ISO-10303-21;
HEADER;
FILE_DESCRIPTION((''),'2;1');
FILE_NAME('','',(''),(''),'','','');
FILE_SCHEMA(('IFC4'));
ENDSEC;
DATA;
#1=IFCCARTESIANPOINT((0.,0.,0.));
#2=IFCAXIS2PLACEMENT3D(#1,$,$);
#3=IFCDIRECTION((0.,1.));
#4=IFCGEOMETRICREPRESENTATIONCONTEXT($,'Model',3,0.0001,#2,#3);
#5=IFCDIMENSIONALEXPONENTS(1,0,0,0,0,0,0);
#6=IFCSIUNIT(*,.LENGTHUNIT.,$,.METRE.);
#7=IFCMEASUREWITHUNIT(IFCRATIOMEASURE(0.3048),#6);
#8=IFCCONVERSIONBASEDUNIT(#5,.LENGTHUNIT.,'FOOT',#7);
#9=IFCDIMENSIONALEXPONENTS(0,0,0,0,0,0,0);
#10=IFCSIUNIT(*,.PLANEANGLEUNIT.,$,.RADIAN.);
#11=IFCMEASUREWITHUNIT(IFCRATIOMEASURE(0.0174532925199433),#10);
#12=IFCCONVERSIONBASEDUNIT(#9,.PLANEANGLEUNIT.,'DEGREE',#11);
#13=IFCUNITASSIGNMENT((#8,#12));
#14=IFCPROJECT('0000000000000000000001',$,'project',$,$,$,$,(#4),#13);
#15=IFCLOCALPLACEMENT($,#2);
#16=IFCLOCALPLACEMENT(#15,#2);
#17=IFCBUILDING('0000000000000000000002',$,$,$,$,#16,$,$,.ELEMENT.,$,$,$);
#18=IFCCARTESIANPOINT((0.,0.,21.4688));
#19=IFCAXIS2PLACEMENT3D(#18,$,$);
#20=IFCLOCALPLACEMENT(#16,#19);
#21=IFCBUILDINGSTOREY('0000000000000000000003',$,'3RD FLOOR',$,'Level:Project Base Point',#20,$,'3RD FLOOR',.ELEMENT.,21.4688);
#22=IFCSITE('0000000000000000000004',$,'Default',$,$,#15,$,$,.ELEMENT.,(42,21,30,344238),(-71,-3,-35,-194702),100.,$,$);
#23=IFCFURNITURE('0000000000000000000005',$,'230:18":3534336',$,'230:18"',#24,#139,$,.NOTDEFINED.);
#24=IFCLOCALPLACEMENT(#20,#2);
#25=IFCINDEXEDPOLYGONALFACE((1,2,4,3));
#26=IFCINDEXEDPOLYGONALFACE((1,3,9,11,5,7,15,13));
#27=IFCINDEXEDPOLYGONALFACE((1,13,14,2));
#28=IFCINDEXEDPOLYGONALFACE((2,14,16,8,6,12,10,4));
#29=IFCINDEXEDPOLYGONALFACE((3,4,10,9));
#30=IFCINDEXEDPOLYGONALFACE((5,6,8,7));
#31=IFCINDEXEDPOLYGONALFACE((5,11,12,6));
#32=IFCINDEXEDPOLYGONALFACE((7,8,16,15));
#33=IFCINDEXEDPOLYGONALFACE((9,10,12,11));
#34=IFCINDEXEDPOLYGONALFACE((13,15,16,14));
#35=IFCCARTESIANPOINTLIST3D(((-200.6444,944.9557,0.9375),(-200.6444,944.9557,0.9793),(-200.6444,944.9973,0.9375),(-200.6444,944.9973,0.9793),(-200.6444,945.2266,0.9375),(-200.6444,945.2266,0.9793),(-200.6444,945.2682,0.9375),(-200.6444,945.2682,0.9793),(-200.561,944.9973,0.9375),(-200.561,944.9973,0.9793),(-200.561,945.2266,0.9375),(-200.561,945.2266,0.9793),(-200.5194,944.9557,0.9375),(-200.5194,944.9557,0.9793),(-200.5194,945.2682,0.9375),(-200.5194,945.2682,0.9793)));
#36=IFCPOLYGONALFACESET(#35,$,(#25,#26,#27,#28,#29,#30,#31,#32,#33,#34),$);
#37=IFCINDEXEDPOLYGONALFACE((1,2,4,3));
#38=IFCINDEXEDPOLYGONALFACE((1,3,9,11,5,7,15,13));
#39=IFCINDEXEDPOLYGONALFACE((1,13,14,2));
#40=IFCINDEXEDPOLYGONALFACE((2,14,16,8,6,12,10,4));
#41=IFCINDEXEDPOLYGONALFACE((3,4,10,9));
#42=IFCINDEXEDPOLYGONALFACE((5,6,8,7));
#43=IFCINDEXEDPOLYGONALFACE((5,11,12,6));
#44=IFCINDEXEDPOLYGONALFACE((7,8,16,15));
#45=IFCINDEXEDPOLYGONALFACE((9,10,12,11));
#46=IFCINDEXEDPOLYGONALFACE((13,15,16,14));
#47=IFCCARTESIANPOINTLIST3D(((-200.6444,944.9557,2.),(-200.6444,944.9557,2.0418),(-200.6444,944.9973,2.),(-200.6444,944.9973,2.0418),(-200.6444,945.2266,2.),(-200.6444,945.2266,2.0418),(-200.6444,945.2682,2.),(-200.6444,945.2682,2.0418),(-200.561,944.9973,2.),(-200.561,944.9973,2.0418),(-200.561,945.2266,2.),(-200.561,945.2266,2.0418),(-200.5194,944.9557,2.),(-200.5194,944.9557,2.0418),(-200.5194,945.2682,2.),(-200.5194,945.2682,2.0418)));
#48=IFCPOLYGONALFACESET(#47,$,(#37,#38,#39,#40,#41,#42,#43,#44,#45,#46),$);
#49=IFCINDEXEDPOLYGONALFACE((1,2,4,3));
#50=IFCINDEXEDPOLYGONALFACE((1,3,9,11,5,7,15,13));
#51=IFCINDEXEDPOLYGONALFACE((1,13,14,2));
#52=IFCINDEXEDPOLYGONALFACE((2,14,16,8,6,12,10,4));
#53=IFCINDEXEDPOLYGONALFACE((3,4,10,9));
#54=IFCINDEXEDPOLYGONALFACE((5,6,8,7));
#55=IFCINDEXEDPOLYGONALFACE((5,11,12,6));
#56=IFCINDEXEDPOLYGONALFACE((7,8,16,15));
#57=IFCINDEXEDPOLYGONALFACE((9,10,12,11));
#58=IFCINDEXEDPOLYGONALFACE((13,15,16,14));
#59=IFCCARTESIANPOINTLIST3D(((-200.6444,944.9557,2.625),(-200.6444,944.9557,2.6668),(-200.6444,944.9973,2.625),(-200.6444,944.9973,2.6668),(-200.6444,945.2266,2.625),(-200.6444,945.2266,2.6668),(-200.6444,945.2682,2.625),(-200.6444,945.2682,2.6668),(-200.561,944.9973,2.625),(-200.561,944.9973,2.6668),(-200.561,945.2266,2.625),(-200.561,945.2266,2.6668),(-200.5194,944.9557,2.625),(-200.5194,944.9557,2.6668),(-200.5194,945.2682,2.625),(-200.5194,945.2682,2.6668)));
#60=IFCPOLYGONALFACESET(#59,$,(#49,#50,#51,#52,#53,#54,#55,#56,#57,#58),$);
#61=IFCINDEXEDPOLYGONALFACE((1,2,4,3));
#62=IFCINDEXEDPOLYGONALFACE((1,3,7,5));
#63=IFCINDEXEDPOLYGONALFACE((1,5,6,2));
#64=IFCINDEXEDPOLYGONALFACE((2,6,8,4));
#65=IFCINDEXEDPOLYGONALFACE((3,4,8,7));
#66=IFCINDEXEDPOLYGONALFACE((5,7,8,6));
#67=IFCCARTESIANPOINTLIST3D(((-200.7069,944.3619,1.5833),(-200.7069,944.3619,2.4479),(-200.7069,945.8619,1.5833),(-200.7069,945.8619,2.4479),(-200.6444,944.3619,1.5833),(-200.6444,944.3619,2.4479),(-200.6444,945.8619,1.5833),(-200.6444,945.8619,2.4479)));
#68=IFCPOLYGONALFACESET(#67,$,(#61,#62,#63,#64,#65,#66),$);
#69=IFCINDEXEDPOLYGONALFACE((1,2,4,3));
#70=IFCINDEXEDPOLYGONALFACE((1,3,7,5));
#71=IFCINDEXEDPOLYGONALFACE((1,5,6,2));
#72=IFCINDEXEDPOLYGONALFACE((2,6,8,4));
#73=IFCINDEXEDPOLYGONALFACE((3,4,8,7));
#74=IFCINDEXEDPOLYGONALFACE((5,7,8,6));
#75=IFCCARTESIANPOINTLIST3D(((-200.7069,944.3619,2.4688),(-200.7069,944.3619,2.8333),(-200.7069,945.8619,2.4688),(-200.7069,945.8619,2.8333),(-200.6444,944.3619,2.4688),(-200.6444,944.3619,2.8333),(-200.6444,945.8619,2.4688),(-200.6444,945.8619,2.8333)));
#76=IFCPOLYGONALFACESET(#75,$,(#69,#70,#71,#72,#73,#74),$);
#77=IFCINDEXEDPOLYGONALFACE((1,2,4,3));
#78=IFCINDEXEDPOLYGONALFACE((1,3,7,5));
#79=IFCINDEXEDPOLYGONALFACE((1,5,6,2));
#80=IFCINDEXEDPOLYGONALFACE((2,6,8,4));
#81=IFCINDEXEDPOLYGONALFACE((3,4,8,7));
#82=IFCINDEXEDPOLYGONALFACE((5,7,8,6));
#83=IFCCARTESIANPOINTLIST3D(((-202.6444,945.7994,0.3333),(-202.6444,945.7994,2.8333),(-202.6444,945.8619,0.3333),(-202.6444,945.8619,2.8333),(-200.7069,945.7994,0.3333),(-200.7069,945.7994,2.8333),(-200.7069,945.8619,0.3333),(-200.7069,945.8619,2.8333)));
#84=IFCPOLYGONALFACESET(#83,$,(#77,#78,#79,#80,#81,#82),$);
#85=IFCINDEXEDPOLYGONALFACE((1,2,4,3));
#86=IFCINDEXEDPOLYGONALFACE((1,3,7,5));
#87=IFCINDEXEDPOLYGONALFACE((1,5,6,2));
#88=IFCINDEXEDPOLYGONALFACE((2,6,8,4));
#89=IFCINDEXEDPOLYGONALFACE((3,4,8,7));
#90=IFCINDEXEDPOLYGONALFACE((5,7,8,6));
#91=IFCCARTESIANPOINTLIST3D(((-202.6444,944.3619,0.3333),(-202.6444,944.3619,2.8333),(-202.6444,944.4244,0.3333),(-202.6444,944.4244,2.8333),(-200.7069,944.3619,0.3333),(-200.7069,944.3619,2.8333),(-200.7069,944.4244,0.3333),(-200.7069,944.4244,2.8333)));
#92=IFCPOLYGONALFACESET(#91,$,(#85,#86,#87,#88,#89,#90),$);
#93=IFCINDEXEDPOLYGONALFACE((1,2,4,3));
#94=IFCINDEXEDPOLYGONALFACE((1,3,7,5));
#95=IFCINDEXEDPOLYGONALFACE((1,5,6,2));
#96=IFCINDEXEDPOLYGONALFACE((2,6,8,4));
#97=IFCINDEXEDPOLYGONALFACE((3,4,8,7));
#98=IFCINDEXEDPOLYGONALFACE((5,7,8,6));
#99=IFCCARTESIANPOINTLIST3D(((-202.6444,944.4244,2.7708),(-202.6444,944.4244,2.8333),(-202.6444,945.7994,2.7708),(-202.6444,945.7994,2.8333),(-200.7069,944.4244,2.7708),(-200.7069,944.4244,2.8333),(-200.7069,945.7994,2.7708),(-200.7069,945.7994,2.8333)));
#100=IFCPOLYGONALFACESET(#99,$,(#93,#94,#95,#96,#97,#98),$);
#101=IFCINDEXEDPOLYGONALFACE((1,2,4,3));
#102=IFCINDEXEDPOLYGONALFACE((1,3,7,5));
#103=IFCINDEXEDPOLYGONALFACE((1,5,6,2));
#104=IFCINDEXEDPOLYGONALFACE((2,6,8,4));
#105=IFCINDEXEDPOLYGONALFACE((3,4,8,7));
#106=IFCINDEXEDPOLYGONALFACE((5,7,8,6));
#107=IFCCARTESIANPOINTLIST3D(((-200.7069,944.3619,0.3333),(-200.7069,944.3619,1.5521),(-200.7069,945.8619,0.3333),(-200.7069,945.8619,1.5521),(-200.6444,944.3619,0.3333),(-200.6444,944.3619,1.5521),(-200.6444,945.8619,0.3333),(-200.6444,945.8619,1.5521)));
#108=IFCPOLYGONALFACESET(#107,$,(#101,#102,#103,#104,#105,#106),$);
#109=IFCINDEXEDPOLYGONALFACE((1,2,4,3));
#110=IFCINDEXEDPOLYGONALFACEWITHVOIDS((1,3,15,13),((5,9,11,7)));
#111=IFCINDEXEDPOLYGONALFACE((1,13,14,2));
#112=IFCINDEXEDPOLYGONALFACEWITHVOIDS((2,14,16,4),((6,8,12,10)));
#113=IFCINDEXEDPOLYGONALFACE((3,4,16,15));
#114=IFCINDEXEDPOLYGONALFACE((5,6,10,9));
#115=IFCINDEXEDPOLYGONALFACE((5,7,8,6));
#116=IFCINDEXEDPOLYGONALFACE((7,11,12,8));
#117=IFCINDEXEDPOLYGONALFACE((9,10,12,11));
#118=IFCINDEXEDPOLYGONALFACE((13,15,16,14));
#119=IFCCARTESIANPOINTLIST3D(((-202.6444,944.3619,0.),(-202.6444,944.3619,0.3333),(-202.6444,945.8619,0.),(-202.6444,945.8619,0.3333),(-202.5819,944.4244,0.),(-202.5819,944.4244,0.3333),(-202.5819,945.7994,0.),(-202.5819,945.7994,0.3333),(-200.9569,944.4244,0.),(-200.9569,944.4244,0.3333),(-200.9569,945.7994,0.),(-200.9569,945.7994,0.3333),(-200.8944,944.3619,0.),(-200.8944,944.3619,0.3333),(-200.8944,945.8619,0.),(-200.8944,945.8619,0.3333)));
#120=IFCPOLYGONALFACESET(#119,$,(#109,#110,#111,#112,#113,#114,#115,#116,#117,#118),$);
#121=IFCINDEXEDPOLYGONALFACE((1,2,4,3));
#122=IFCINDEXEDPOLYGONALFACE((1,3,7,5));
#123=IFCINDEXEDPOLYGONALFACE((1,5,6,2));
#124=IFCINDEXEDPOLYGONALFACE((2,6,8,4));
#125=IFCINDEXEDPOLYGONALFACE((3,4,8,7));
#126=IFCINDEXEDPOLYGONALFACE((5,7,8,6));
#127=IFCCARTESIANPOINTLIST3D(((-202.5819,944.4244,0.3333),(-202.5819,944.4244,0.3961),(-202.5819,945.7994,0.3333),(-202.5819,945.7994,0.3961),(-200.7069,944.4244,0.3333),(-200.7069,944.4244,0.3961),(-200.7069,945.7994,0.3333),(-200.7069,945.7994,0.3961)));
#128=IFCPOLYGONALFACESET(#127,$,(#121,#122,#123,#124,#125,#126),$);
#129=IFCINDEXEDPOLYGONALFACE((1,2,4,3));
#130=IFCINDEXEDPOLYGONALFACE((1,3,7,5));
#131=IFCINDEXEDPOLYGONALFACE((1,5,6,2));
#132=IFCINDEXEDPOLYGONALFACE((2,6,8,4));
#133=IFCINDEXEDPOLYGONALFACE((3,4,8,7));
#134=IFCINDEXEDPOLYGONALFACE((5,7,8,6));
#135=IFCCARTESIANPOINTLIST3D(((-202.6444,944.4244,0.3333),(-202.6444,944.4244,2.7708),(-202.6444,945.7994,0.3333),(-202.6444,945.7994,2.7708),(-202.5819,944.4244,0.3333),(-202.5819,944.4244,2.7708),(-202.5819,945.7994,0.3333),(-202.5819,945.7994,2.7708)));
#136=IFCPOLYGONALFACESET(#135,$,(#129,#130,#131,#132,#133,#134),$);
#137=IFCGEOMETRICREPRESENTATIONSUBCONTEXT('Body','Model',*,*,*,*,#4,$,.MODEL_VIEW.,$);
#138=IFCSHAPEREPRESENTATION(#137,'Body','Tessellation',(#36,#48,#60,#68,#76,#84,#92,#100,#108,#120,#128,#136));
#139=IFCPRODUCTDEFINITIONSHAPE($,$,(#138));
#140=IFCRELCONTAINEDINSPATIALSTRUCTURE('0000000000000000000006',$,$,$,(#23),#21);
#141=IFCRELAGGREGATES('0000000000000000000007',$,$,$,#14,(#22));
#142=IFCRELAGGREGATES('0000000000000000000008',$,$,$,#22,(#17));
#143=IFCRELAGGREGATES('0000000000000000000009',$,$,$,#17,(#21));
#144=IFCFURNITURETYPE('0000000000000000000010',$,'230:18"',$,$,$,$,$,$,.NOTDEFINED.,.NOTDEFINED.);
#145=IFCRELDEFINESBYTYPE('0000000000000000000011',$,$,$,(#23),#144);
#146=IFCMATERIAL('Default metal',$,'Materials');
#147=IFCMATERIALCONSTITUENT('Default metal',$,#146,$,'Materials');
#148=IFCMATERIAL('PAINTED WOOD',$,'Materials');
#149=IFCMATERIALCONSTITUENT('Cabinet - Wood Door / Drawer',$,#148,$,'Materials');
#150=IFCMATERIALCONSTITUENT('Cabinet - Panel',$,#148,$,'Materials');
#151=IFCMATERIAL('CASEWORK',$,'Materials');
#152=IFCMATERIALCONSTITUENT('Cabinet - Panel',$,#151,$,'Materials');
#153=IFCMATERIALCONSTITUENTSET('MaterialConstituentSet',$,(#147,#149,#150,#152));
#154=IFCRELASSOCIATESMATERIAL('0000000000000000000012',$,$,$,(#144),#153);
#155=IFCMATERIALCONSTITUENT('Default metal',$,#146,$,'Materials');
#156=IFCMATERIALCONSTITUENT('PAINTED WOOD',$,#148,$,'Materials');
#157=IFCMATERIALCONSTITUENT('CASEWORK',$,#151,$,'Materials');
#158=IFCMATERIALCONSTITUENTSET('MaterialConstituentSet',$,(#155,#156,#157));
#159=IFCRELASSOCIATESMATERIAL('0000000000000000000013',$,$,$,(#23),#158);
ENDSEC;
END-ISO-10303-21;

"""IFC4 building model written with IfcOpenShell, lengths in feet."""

from ifc_helpers import new_model, entity, si_unit, converted_unit, direction, frame, frame_2d, origin, origin_2d_with_axis, place, context, subcontext, project, spatial, polyline, rectangle, outline, extrude, source, transform, mapped, material, constituent, constituent_set, type_object, type_shapes, element, save


model = new_model("IFC4")

# Units and contexts
model_context = context("Model", 3, precision=0.0001, world=origin(), true_north=direction((0.0, 1.0)))
body_context = subcontext(model_context, "Body", "Model", "MODEL_VIEW")
ifc_project = project(units=[converted_unit("LENGTHUNIT", "FOOT", entity("IfcRatioMeasure", 0.3048), si_unit("LENGTHUNIT", "METRE"), dimensions=[1, 0, 0, 0, 0, 0, 0]), converted_unit("PLANEANGLEUNIT", "DEGREE", entity("IfcRatioMeasure", 0.0174532925199433), si_unit("PLANEANGLEUNIT", "RADIAN"), dimensions=[0, 0, 0, 0, 0, 0, 0])], contexts=[model_context])

# Site, building, storey
site_placement = place(None, origin())
site = spatial("IfcSite", under=ifc_project, at=site_placement, Name="Default", CompositionType="ELEMENT", RefLatitude=(42, 21, 30, 344238), RefLongitude=(-71, -3, -35, -194702), RefElevation=100.0)
building_placement = place(site_placement, origin())
building = spatial("IfcBuilding", under=site, at=building_placement, CompositionType="ELEMENT")
storey_placement = place(building_placement, frame((0.0, 0.0, 21.4688)))
storey = spatial("IfcBuildingStorey", under=building, at=storey_placement, Name="3RD FLOOR", ObjectType="Level:Project Base Point", LongName="3RD FLOOR", CompositionType="ELEMENT", Elevation=21.4688)

# Furniture
ifc_material_1 = material(Name="Default metal", Category="Materials")
ifc_material_2 = material(Name="PAINTED WOOD", Category="Materials")
ifc_material_3 = material(Name="CASEWORK", Category="Materials")
ifc_constituent_1 = constituent(ifc_material_1, Name="Default metal", Category="Materials")
ifc_constituent_2 = constituent(ifc_material_2, Name="PAINTED WOOD", Category="Materials")
ifc_constituent_3 = constituent(ifc_material_3, Name="CASEWORK", Category="Materials")
ifc_constituent_set_1 = constituent_set(constituents=[ifc_constituent_1, ifc_constituent_2, ifc_constituent_3], Name="MaterialConstituentSet")
ifc_constituent_4 = constituent(ifc_material_1, Name="Default metal", Category="Materials")
ifc_constituent_5 = constituent(ifc_material_2, Name="Cabinet - Wood Door / Drawer", Category="Materials")
ifc_constituent_6 = constituent(ifc_material_2, Name="Cabinet - Panel", Category="Materials")
ifc_constituent_7 = constituent(ifc_material_3, Name="Cabinet - Panel", Category="Materials")
ifc_constituent_set_2 = constituent_set(constituents=[ifc_constituent_4, ifc_constituent_5, ifc_constituent_6, ifc_constituent_7], Name="MaterialConstituentSet")
furniture_type_1 = type_object("IfcFurnitureType", Name="230:18\"", AssemblyPlace="NOTDEFINED", PredefinedType="NOTDEFINED", material=ifc_constituent_set_2)
shared_shape_1 = source(origin(), body_context, "Body", "SweptSolid", [
    extrude(outline(polyline([(-0.1562, -0.0521), (-0.1146, -0.0521), (-0.1146, 0.0313), (0.1146, 0.0313), (0.1146, -0.0521), (0.1562, -0.0521), (0.1562, 0.0729), (-0.1562, 0.0729), (-0.1562, -0.0521)])), frame((0.0615, 2.0521, 0.9375)), (0.0, 0.0, 1.0), 0.0418),
    extrude(outline(polyline([(-0.1562, -0.0521), (-0.1146, -0.0521), (-0.1146, 0.0313), (0.1146, 0.0313), (0.1146, -0.0521), (0.1562, -0.0521), (0.1562, 0.0729), (-0.1562, 0.0729), (-0.1562, -0.0521)])), frame((0.0615, 2.0521, 2.0)), (0.0, 0.0, 1.0), 0.0418),
    extrude(outline(polyline([(-0.1562, -0.0521), (-0.1146, -0.0521), (-0.1146, 0.0313), (0.1146, 0.0313), (0.1146, -0.0521), (0.1562, -0.0521), (0.1562, 0.0729), (-0.1562, 0.0729), (-0.1562, -0.0521)])), frame((0.0615, 2.0521, 2.625)), (0.0, 0.0, 1.0), 0.0418),
    extrude(rectangle(XDim=1.5, YDim=0.0625, at=frame_2d((0.0, 0.0), x_axis=(1.0, 0.0))), frame((0.0615, 1.9688, 1.5833), z_axis=(0.0, 0.0, 1.0), x_axis=(-1.0, 0.0, 0.0)), (0.0, 0.0, 1.0), 0.8646),
    extrude(rectangle(XDim=1.5, YDim=0.0625, at=frame_2d((0.0, 0.0), x_axis=(1.0, 0.0))), frame((0.0615, 1.9688, 2.4688), z_axis=(0.0, 0.0, 1.0), x_axis=(-1.0, 0.0, 0.0)), (0.0, 0.0, 1.0), 0.3646),
    extrude(rectangle(XDim=1.9375, YDim=0.0625, at=frame_2d((0.0, 0.0), x_axis=(1.0, 0.0))), frame((-0.6573, 0.9687, 0.3333), z_axis=(0.0, 0.0, 1.0), x_axis=(0.0, -1.0, 0.0)), (0.0, 0.0, 1.0), 2.5),
    extrude(rectangle(XDim=1.9375, YDim=0.0625, at=frame_2d((0.0, 0.0), x_axis=(1.0, 0.0))), frame((0.7802, 0.9687, 0.3333), z_axis=(0.0, 0.0, 1.0), x_axis=(0.0, -1.0, 0.0)), (0.0, 0.0, 1.0), 2.5),
    extrude(rectangle(XDim=1.9375, YDim=1.375, at=origin_2d_with_axis()), frame((0.0615, 0.9687, 2.7708), z_axis=(0.0, 0.0, 1.0), x_axis=(0.0, 1.0, 0.0)), (0.0, 0.0, 1.0), 0.0625),
    extrude(rectangle(XDim=1.5, YDim=0.0625, at=frame_2d((0.0, 0.0), x_axis=(1.0, 0.0))), frame((0.0615, 1.9688, 0.3333), z_axis=(0.0, 0.0, 1.0), x_axis=(-1.0, 0.0, 0.0)), (0.0, 0.0, 1.0), 1.2187),
    extrude(outline(polyline([(-0.875, -0.75), (0.875, -0.75), (0.875, 0.75), (-0.875, 0.75), (-0.875, -0.75)]), holes=[polyline([(-0.8125, -0.6875), (-0.8125, 0.6875), (0.8125, 0.6875), (0.8125, -0.6875), (-0.8125, -0.6875)])]), frame((0.0615, 0.875, 0.0), z_axis=(0.0, 0.0, 1.0), x_axis=(0.0, -1.0, 0.0)), (0.0, 0.0, 1.0), 0.3333),
    extrude(rectangle(XDim=1.875, YDim=1.375, at=origin_2d_with_axis()), frame((0.0615, 1.0, 0.3333), z_axis=(0.0, 0.0, 1.0), x_axis=(0.0, 1.0, 0.0)), (0.0, 0.0, 1.0), 0.0627),
    extrude(rectangle(XDim=1.375, YDim=0.0625, at=origin_2d_with_axis()), frame((0.0615, 0.0312, 0.3333), z_axis=(0.0, 0.0, 1.0), x_axis=(-1.0, 0.0, 0.0)), (0.0, 0.0, 1.0), 2.4375),
])
type_shapes(furniture_type_1, [shared_shape_1])
furniture_1_placement = place(storey_placement, frame((-202.6444, 945.1734, 0.0), z_axis=(0.0, 0.0, 1.0), x_axis=(0.0, -1.0, 0.0)))
element("IfcFurniture", 1, at=furniture_1_placement, inside=storey, type_object=furniture_type_1, material=ifc_constituent_set_1, Name="230:18\":3534336", ObjectType="230:18\"", PredefinedType="NOTDEFINED", context=body_context, shape_type="MappedRepresentation", body=[
    mapped(shared_shape_1, transform((0.0, 0.0, 0.0), scale=1.0)),
])

save(model, "model.ifc")
